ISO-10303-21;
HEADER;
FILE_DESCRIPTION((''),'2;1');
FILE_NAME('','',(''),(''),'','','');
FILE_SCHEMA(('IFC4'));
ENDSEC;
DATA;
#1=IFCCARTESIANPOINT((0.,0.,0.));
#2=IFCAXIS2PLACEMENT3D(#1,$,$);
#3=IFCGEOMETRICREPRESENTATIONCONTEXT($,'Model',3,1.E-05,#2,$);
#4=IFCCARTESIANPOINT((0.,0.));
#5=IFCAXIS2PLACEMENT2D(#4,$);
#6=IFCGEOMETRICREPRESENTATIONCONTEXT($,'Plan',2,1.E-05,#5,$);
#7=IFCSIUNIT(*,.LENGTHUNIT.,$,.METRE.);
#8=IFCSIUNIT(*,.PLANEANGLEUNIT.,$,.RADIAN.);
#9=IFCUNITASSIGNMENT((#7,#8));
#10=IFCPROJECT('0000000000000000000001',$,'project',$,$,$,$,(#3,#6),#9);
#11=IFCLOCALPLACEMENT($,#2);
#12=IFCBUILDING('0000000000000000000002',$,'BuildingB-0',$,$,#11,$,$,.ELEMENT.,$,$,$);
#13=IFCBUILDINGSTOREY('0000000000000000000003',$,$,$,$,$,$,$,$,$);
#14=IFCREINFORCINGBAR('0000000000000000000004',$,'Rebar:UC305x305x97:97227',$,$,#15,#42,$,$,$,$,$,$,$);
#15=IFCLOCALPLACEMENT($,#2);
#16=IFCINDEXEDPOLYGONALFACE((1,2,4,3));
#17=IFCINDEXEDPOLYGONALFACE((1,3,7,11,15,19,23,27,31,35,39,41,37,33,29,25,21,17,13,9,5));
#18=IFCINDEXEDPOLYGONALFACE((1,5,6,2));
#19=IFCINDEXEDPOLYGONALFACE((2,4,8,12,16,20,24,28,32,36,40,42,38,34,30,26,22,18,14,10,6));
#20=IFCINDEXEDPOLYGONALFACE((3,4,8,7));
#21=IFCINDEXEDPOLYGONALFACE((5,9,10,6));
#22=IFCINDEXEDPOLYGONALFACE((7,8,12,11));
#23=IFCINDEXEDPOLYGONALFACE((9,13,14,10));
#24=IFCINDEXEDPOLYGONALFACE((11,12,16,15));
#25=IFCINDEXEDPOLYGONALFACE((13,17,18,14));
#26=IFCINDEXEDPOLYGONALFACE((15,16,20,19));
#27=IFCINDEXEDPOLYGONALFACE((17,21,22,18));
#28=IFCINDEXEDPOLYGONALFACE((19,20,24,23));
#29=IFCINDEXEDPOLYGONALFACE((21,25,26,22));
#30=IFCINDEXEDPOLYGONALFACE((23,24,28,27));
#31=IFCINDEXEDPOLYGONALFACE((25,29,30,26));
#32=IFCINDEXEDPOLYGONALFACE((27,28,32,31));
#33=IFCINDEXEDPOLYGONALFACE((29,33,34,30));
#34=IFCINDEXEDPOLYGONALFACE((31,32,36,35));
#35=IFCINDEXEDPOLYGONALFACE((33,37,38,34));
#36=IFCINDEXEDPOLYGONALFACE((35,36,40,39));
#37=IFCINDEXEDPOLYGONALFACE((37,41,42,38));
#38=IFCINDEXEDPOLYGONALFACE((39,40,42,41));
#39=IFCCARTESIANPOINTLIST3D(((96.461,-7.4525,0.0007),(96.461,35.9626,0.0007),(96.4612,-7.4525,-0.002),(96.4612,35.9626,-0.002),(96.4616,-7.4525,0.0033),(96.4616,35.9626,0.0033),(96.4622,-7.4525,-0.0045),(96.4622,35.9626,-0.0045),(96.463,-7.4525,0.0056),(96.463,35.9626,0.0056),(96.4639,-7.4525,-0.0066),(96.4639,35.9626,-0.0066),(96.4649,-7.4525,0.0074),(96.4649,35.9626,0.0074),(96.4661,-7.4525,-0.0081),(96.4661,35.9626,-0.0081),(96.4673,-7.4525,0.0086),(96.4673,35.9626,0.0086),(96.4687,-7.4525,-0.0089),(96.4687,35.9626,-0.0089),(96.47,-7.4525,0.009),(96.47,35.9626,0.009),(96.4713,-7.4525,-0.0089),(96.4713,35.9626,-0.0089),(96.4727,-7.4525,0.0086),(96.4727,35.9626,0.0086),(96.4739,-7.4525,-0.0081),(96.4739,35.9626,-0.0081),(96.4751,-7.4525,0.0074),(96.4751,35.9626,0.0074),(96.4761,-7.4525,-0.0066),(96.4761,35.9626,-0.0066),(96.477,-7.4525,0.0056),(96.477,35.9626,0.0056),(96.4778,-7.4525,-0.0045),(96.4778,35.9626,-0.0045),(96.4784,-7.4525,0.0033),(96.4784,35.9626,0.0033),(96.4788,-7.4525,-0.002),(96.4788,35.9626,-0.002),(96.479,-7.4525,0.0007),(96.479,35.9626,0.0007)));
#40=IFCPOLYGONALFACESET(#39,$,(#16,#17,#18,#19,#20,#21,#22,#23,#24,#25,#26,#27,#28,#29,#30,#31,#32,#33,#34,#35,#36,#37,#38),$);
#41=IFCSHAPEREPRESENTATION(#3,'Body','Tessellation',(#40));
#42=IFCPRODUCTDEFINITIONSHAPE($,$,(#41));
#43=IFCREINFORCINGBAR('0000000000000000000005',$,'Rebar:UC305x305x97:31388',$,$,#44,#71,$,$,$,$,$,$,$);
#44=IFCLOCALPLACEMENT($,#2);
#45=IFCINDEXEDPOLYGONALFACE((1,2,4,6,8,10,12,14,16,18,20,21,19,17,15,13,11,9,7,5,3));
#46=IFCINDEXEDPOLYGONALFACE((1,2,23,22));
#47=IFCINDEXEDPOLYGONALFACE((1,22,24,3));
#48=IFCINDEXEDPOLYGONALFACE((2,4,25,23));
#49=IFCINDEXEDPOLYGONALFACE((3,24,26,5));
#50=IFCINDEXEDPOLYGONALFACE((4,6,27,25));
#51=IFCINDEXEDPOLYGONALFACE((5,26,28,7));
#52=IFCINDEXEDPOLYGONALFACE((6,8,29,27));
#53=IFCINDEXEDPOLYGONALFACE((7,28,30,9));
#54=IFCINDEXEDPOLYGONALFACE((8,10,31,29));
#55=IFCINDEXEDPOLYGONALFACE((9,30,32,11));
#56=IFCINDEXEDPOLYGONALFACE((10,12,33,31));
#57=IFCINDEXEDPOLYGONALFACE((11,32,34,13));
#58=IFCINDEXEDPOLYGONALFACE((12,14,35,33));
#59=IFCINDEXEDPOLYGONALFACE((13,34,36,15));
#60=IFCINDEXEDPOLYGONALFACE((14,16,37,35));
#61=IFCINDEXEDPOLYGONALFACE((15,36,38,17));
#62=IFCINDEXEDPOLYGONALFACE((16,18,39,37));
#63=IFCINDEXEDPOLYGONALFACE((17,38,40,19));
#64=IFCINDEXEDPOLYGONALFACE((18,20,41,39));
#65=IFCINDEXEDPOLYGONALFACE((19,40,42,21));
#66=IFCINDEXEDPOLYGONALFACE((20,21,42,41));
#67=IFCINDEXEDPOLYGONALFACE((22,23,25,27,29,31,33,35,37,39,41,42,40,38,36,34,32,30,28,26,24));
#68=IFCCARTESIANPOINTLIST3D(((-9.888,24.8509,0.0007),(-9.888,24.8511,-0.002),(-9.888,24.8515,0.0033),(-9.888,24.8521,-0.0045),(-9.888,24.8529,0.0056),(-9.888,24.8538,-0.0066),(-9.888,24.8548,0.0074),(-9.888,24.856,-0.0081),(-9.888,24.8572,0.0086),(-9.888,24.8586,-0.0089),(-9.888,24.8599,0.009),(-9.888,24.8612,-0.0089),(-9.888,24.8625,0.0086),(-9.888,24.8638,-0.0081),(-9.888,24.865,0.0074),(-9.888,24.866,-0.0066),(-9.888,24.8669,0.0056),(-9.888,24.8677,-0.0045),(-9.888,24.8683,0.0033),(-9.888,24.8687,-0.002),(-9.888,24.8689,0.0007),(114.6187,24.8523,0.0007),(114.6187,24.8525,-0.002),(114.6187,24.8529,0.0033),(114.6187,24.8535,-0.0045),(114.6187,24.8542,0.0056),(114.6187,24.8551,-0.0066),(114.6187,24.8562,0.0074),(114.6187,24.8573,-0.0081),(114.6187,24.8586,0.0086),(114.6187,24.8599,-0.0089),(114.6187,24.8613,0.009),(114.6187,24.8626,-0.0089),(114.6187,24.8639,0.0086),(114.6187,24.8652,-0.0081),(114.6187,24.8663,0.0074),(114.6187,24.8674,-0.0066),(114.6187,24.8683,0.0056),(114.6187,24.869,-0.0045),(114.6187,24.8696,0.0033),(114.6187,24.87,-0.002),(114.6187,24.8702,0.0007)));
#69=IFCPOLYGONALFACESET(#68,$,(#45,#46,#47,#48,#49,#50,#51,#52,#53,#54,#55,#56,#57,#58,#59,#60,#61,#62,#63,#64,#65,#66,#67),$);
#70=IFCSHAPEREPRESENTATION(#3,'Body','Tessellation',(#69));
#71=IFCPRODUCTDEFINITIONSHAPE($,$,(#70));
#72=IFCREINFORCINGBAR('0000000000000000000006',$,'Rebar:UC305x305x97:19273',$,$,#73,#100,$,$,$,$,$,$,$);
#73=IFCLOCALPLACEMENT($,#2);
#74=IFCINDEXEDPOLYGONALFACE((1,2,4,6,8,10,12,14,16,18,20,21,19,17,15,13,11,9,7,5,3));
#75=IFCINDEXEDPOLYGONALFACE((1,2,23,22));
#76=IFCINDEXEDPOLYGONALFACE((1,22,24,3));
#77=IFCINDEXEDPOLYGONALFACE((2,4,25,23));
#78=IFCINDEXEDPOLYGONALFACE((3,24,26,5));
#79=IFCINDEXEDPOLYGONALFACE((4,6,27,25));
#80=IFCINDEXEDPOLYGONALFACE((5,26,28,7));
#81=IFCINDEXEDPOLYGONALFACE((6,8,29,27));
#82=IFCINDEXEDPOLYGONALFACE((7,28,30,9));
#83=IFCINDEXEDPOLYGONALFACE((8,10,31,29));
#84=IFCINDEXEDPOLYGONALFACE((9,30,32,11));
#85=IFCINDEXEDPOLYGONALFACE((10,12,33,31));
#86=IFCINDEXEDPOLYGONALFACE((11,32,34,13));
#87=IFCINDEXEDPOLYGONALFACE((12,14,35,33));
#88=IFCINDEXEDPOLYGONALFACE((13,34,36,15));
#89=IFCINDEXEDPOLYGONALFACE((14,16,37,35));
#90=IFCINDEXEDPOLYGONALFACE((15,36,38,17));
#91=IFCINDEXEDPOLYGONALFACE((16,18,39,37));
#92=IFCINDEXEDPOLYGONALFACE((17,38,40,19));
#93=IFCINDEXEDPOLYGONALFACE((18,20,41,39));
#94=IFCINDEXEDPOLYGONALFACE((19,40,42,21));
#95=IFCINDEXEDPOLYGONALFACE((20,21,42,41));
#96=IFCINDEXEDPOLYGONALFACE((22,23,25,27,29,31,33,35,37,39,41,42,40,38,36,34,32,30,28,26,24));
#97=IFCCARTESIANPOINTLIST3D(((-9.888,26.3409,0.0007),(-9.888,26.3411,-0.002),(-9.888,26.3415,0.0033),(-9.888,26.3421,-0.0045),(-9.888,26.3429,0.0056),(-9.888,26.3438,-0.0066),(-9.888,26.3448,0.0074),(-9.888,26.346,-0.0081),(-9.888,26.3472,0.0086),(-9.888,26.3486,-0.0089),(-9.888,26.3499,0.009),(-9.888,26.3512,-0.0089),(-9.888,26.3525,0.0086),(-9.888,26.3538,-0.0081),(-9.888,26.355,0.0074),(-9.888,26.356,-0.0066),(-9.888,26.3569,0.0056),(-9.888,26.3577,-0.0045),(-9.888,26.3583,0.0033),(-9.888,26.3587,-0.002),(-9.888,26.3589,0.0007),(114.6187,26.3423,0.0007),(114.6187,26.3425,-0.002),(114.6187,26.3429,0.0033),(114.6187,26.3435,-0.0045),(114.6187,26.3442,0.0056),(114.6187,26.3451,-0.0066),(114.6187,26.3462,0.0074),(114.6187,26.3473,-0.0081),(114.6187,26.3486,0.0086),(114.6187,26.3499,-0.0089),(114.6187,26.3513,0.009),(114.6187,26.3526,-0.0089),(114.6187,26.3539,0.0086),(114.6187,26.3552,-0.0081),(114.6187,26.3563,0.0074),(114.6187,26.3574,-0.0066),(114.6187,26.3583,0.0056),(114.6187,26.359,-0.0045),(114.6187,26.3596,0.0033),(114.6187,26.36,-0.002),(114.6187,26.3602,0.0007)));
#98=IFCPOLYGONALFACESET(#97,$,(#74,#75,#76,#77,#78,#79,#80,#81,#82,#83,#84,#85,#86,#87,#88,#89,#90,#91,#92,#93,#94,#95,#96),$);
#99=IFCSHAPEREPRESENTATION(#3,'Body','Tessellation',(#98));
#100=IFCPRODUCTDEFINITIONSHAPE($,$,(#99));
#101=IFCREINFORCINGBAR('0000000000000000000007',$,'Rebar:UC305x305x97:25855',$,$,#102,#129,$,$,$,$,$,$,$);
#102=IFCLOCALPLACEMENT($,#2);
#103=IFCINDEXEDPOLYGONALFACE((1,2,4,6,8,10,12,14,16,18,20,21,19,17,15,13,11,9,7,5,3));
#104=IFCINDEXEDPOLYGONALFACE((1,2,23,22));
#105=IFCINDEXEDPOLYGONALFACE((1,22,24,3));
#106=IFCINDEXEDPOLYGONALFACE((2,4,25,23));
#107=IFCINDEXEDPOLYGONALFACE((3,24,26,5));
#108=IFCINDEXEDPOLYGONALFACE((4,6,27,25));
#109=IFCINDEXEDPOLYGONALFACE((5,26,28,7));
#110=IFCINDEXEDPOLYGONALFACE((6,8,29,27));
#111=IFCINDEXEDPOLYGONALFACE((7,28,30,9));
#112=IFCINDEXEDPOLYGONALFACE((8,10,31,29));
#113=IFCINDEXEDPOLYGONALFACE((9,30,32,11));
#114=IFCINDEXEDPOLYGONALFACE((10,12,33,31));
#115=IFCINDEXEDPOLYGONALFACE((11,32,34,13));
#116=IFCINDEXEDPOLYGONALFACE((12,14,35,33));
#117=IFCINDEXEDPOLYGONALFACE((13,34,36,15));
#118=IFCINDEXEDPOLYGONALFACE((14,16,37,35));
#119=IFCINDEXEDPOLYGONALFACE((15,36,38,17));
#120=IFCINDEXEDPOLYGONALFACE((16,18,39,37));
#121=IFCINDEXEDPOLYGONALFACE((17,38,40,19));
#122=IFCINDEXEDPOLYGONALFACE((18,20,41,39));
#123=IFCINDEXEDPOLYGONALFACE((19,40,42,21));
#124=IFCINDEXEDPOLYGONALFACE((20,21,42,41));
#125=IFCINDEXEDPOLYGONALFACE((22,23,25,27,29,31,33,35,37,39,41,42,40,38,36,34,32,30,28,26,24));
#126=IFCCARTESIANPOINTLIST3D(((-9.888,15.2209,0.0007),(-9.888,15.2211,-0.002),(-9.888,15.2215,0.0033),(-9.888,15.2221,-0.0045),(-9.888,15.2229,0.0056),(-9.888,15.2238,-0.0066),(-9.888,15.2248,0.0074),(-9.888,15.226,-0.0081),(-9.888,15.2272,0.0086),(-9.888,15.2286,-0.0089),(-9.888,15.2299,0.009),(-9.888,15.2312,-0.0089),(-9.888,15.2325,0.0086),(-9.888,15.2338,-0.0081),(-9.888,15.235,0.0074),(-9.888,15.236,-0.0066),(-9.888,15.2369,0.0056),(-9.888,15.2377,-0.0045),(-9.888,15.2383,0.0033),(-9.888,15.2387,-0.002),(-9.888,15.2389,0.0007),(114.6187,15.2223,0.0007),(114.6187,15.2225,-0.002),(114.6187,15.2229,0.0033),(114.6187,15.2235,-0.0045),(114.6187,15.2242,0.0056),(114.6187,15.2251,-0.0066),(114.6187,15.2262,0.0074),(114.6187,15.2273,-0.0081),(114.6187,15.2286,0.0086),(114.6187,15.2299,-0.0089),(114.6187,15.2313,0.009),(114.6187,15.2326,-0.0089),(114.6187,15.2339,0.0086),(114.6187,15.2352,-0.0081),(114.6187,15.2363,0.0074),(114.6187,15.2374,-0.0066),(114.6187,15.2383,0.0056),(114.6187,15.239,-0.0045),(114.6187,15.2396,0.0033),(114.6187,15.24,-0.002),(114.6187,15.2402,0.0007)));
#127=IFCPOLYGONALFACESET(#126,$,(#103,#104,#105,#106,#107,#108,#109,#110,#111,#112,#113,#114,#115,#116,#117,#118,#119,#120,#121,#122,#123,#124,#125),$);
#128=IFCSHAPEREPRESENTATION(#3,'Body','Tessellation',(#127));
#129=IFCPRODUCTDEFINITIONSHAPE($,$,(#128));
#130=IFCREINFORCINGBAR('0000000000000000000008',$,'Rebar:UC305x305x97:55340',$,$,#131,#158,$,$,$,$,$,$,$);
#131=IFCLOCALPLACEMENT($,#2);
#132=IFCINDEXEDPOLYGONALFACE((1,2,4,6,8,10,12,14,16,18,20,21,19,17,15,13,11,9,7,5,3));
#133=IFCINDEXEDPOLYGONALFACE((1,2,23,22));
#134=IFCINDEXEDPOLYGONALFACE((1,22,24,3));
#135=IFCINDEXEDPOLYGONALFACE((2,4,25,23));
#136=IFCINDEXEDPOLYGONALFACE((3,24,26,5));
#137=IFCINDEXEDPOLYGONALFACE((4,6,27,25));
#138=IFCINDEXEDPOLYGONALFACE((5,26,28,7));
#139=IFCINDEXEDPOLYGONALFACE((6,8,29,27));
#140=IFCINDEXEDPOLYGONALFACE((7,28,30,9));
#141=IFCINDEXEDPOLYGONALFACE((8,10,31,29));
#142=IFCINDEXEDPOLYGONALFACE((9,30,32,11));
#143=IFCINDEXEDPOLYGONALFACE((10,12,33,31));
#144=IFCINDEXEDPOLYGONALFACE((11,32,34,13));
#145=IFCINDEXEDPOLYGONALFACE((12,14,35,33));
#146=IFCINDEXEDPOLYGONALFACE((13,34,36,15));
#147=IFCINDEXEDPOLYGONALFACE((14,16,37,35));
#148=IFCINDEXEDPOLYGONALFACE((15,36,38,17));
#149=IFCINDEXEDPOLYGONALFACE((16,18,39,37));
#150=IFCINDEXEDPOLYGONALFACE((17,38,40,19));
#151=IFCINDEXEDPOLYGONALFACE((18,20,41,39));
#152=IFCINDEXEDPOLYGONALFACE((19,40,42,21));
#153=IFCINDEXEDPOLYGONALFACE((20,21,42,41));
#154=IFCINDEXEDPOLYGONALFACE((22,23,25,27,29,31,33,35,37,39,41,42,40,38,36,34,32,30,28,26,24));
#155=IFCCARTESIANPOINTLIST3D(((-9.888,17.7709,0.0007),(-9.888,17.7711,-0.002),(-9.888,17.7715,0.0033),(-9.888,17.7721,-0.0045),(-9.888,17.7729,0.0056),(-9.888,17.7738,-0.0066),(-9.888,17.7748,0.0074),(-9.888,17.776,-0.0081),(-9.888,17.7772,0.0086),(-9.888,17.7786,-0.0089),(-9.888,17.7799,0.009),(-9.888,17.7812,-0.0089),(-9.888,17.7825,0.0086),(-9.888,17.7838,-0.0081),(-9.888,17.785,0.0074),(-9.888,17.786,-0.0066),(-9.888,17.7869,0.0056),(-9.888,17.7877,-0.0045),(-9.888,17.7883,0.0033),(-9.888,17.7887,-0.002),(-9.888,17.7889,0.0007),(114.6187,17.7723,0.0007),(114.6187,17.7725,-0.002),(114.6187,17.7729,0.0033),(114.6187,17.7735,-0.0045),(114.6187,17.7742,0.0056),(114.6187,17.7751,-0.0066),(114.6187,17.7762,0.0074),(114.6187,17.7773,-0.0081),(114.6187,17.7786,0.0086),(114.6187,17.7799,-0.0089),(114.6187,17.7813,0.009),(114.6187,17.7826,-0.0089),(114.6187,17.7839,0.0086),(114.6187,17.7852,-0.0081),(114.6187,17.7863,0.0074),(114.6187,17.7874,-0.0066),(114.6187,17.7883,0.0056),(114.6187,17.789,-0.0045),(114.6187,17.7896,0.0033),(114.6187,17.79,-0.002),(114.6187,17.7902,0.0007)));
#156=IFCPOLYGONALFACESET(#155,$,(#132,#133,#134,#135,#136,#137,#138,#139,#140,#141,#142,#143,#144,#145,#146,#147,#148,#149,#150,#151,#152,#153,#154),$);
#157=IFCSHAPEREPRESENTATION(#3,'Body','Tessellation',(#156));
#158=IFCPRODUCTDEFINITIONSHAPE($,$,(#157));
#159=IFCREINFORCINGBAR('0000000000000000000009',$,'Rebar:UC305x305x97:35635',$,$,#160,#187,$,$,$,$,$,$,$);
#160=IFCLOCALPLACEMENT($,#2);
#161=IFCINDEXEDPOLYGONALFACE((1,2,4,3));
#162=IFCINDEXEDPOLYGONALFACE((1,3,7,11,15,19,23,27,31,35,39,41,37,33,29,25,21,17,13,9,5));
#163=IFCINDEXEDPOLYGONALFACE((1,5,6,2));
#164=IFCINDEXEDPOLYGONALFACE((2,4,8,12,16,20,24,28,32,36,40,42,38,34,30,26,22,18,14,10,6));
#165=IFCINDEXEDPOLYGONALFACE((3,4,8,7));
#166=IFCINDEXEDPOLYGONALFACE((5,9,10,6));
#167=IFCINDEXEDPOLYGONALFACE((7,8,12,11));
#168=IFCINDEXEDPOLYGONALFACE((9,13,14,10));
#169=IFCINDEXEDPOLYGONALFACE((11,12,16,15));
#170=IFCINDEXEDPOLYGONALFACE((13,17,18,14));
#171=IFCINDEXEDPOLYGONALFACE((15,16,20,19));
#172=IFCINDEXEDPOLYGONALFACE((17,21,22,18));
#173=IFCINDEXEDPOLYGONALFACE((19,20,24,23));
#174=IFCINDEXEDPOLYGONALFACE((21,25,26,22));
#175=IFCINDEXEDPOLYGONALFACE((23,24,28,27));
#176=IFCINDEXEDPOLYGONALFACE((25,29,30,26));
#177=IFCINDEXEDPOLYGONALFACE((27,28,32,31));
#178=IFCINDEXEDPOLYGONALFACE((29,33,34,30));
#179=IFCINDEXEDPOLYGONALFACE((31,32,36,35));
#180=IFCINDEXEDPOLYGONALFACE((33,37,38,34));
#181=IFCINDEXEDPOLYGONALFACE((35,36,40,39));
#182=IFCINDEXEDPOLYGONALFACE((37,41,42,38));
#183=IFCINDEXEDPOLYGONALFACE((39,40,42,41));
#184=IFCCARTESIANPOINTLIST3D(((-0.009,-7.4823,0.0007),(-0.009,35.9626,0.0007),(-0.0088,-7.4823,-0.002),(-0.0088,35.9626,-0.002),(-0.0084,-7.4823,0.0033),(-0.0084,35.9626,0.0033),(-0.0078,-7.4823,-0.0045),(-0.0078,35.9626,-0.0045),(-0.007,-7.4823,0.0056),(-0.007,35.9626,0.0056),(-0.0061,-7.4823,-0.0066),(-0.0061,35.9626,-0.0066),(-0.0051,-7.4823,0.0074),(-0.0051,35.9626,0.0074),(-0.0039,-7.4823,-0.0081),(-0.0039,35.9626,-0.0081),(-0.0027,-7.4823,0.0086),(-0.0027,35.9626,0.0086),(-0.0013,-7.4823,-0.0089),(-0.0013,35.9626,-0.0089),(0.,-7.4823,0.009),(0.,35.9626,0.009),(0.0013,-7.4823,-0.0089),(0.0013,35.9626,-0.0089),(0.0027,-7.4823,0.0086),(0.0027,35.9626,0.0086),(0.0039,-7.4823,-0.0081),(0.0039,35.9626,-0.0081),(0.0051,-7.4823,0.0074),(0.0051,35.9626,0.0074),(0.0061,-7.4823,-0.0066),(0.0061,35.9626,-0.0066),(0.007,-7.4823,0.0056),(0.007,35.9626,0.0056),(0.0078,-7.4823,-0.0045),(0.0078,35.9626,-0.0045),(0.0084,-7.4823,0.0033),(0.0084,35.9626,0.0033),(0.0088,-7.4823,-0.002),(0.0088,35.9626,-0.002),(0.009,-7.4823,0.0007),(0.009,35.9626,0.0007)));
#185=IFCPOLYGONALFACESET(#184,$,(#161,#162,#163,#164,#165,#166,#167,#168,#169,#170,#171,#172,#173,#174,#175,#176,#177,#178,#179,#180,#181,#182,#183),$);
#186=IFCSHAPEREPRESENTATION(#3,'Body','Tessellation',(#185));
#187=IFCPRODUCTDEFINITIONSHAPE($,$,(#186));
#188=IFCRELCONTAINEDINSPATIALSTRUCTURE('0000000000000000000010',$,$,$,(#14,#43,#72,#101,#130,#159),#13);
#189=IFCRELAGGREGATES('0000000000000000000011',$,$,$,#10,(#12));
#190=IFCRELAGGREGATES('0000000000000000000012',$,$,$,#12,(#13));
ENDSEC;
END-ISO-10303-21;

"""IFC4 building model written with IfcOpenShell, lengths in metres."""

from ifc_helpers import new_model, entity, si_unit, origin, origin_2d, place, context, project, spatial, element, save


model = new_model("IFC4")

# Units and contexts
model_context = context("Model", 3, precision=1e-05, world=origin())
plan_context = context("Plan", 2, precision=1e-05, world=origin_2d())
ifc_project = project(units=[si_unit("LENGTHUNIT", "METRE"), si_unit("PLANEANGLEUNIT", "RADIAN")], contexts=[model_context, plan_context])

# Building, storey
building_placement = place(None, origin())
building = spatial("IfcBuilding", under=ifc_project, at=building_placement, Name="BuildingB-0", CompositionType="ELEMENT")
storey = spatial("IfcBuildingStorey", under=building)

# Reinforcing bars
element("IfcReinforcingBar", 1, inside=storey, Name="Rebar:UC305x305x97:97227", context=model_context, shape_type="SweptSolid", body=[
    entity("IfcSurfaceCurveSweptAreaSolid", entity("IfcCircleProfileDef", "AREA", None, None, 0.009), None, entity("IfcPolyline", [entity("IfcCartesianPoint", [96.47, 35.9626, 0.0]), entity("IfcCartesianPoint", [96.47, -7.4525, 0.0])]), None, None, entity("IfcPlane", entity("IfcAxis2Placement3D", entity("IfcCartesianPoint", [96.47, 35.9626, 0.0]), entity("IfcDirection", [0.0, 0.0, 1.0]), entity("IfcDirection", [1.0, 0.0, 0.0])))),
])
element("IfcReinforcingBar", 2, inside=storey, Name="Rebar:UC305x305x97:31388", context=model_context, shape_type="SweptSolid", body=[
    entity("IfcSurfaceCurveSweptAreaSolid", entity("IfcCircleProfileDef", "AREA", None, None, 0.009), None, entity("IfcPolyline", [entity("IfcCartesianPoint", [-9.888, 24.8599, 0.0]), entity("IfcCartesianPoint", [114.6187, 24.8613, 0.0])]), None, None, entity("IfcPlane", entity("IfcAxis2Placement3D", entity("IfcCartesianPoint", [-9.888, 24.8599, 0.0]), entity("IfcDirection", [0.0, 0.0, 1.0]), entity("IfcDirection", [1.0, 0.0, 0.0])))),
])
element("IfcReinforcingBar", 3, inside=storey, Name="Rebar:UC305x305x97:19273", context=model_context, shape_type="SweptSolid", body=[
    entity("IfcSurfaceCurveSweptAreaSolid", entity("IfcCircleProfileDef", "AREA", None, None, 0.009), None, entity("IfcPolyline", [entity("IfcCartesianPoint", [-9.888, 26.3499, 0.0]), entity("IfcCartesianPoint", [114.6187, 26.3513, 0.0])]), None, None, entity("IfcPlane", entity("IfcAxis2Placement3D", entity("IfcCartesianPoint", [-9.888, 26.3499, 0.0]), entity("IfcDirection", [0.0, 0.0, 1.0]), entity("IfcDirection", [1.0, 0.0, 0.0])))),
])
element("IfcReinforcingBar", 4, inside=storey, Name="Rebar:UC305x305x97:25855", context=model_context, shape_type="SweptSolid", body=[
    entity("IfcSurfaceCurveSweptAreaSolid", entity("IfcCircleProfileDef", "AREA", None, None, 0.009), None, entity("IfcPolyline", [entity("IfcCartesianPoint", [-9.888, 15.2299, 0.0]), entity("IfcCartesianPoint", [114.6187, 15.2313, 0.0])]), None, None, entity("IfcPlane", entity("IfcAxis2Placement3D", entity("IfcCartesianPoint", [-9.888, 15.2299, 0.0]), entity("IfcDirection", [0.0, 0.0, 1.0]), entity("IfcDirection", [1.0, 0.0, 0.0])))),
])
element("IfcReinforcingBar", 5, inside=storey, Name="Rebar:UC305x305x97:55340", context=model_context, shape_type="SweptSolid", body=[
    entity("IfcSurfaceCurveSweptAreaSolid", entity("IfcCircleProfileDef", "AREA", None, None, 0.009), None, entity("IfcPolyline", [entity("IfcCartesianPoint", [-9.888, 17.7799, 0.0]), entity("IfcCartesianPoint", [114.6187, 17.7813, 0.0])]), None, None, entity("IfcPlane", entity("IfcAxis2Placement3D", entity("IfcCartesianPoint", [-9.888, 17.7799, 0.0]), entity("IfcDirection", [0.0, 0.0, 1.0]), entity("IfcDirection", [1.0, 0.0, 0.0])))),
])
element("IfcReinforcingBar", 6, inside=storey, Name="Rebar:UC305x305x97:35635", context=model_context, shape_type="SweptSolid", body=[
    entity("IfcSurfaceCurveSweptAreaSolid", entity("IfcCircleProfileDef", "AREA", None, None, 0.009), None, entity("IfcPolyline", [entity("IfcCartesianPoint", [0.0, 35.9626, 0.0]), entity("IfcCartesianPoint", [0.0, -7.4823, 0.0])]), None, None, entity("IfcPlane", entity("IfcAxis2Placement3D", entity("IfcCartesianPoint", [0.0, 35.9626, 0.0]), entity("IfcDirection", [0.0, 0.0, 1.0]), entity("IfcDirection", [1.0, 0.0, 0.0])))),
])

save(model, "model.ifc")
